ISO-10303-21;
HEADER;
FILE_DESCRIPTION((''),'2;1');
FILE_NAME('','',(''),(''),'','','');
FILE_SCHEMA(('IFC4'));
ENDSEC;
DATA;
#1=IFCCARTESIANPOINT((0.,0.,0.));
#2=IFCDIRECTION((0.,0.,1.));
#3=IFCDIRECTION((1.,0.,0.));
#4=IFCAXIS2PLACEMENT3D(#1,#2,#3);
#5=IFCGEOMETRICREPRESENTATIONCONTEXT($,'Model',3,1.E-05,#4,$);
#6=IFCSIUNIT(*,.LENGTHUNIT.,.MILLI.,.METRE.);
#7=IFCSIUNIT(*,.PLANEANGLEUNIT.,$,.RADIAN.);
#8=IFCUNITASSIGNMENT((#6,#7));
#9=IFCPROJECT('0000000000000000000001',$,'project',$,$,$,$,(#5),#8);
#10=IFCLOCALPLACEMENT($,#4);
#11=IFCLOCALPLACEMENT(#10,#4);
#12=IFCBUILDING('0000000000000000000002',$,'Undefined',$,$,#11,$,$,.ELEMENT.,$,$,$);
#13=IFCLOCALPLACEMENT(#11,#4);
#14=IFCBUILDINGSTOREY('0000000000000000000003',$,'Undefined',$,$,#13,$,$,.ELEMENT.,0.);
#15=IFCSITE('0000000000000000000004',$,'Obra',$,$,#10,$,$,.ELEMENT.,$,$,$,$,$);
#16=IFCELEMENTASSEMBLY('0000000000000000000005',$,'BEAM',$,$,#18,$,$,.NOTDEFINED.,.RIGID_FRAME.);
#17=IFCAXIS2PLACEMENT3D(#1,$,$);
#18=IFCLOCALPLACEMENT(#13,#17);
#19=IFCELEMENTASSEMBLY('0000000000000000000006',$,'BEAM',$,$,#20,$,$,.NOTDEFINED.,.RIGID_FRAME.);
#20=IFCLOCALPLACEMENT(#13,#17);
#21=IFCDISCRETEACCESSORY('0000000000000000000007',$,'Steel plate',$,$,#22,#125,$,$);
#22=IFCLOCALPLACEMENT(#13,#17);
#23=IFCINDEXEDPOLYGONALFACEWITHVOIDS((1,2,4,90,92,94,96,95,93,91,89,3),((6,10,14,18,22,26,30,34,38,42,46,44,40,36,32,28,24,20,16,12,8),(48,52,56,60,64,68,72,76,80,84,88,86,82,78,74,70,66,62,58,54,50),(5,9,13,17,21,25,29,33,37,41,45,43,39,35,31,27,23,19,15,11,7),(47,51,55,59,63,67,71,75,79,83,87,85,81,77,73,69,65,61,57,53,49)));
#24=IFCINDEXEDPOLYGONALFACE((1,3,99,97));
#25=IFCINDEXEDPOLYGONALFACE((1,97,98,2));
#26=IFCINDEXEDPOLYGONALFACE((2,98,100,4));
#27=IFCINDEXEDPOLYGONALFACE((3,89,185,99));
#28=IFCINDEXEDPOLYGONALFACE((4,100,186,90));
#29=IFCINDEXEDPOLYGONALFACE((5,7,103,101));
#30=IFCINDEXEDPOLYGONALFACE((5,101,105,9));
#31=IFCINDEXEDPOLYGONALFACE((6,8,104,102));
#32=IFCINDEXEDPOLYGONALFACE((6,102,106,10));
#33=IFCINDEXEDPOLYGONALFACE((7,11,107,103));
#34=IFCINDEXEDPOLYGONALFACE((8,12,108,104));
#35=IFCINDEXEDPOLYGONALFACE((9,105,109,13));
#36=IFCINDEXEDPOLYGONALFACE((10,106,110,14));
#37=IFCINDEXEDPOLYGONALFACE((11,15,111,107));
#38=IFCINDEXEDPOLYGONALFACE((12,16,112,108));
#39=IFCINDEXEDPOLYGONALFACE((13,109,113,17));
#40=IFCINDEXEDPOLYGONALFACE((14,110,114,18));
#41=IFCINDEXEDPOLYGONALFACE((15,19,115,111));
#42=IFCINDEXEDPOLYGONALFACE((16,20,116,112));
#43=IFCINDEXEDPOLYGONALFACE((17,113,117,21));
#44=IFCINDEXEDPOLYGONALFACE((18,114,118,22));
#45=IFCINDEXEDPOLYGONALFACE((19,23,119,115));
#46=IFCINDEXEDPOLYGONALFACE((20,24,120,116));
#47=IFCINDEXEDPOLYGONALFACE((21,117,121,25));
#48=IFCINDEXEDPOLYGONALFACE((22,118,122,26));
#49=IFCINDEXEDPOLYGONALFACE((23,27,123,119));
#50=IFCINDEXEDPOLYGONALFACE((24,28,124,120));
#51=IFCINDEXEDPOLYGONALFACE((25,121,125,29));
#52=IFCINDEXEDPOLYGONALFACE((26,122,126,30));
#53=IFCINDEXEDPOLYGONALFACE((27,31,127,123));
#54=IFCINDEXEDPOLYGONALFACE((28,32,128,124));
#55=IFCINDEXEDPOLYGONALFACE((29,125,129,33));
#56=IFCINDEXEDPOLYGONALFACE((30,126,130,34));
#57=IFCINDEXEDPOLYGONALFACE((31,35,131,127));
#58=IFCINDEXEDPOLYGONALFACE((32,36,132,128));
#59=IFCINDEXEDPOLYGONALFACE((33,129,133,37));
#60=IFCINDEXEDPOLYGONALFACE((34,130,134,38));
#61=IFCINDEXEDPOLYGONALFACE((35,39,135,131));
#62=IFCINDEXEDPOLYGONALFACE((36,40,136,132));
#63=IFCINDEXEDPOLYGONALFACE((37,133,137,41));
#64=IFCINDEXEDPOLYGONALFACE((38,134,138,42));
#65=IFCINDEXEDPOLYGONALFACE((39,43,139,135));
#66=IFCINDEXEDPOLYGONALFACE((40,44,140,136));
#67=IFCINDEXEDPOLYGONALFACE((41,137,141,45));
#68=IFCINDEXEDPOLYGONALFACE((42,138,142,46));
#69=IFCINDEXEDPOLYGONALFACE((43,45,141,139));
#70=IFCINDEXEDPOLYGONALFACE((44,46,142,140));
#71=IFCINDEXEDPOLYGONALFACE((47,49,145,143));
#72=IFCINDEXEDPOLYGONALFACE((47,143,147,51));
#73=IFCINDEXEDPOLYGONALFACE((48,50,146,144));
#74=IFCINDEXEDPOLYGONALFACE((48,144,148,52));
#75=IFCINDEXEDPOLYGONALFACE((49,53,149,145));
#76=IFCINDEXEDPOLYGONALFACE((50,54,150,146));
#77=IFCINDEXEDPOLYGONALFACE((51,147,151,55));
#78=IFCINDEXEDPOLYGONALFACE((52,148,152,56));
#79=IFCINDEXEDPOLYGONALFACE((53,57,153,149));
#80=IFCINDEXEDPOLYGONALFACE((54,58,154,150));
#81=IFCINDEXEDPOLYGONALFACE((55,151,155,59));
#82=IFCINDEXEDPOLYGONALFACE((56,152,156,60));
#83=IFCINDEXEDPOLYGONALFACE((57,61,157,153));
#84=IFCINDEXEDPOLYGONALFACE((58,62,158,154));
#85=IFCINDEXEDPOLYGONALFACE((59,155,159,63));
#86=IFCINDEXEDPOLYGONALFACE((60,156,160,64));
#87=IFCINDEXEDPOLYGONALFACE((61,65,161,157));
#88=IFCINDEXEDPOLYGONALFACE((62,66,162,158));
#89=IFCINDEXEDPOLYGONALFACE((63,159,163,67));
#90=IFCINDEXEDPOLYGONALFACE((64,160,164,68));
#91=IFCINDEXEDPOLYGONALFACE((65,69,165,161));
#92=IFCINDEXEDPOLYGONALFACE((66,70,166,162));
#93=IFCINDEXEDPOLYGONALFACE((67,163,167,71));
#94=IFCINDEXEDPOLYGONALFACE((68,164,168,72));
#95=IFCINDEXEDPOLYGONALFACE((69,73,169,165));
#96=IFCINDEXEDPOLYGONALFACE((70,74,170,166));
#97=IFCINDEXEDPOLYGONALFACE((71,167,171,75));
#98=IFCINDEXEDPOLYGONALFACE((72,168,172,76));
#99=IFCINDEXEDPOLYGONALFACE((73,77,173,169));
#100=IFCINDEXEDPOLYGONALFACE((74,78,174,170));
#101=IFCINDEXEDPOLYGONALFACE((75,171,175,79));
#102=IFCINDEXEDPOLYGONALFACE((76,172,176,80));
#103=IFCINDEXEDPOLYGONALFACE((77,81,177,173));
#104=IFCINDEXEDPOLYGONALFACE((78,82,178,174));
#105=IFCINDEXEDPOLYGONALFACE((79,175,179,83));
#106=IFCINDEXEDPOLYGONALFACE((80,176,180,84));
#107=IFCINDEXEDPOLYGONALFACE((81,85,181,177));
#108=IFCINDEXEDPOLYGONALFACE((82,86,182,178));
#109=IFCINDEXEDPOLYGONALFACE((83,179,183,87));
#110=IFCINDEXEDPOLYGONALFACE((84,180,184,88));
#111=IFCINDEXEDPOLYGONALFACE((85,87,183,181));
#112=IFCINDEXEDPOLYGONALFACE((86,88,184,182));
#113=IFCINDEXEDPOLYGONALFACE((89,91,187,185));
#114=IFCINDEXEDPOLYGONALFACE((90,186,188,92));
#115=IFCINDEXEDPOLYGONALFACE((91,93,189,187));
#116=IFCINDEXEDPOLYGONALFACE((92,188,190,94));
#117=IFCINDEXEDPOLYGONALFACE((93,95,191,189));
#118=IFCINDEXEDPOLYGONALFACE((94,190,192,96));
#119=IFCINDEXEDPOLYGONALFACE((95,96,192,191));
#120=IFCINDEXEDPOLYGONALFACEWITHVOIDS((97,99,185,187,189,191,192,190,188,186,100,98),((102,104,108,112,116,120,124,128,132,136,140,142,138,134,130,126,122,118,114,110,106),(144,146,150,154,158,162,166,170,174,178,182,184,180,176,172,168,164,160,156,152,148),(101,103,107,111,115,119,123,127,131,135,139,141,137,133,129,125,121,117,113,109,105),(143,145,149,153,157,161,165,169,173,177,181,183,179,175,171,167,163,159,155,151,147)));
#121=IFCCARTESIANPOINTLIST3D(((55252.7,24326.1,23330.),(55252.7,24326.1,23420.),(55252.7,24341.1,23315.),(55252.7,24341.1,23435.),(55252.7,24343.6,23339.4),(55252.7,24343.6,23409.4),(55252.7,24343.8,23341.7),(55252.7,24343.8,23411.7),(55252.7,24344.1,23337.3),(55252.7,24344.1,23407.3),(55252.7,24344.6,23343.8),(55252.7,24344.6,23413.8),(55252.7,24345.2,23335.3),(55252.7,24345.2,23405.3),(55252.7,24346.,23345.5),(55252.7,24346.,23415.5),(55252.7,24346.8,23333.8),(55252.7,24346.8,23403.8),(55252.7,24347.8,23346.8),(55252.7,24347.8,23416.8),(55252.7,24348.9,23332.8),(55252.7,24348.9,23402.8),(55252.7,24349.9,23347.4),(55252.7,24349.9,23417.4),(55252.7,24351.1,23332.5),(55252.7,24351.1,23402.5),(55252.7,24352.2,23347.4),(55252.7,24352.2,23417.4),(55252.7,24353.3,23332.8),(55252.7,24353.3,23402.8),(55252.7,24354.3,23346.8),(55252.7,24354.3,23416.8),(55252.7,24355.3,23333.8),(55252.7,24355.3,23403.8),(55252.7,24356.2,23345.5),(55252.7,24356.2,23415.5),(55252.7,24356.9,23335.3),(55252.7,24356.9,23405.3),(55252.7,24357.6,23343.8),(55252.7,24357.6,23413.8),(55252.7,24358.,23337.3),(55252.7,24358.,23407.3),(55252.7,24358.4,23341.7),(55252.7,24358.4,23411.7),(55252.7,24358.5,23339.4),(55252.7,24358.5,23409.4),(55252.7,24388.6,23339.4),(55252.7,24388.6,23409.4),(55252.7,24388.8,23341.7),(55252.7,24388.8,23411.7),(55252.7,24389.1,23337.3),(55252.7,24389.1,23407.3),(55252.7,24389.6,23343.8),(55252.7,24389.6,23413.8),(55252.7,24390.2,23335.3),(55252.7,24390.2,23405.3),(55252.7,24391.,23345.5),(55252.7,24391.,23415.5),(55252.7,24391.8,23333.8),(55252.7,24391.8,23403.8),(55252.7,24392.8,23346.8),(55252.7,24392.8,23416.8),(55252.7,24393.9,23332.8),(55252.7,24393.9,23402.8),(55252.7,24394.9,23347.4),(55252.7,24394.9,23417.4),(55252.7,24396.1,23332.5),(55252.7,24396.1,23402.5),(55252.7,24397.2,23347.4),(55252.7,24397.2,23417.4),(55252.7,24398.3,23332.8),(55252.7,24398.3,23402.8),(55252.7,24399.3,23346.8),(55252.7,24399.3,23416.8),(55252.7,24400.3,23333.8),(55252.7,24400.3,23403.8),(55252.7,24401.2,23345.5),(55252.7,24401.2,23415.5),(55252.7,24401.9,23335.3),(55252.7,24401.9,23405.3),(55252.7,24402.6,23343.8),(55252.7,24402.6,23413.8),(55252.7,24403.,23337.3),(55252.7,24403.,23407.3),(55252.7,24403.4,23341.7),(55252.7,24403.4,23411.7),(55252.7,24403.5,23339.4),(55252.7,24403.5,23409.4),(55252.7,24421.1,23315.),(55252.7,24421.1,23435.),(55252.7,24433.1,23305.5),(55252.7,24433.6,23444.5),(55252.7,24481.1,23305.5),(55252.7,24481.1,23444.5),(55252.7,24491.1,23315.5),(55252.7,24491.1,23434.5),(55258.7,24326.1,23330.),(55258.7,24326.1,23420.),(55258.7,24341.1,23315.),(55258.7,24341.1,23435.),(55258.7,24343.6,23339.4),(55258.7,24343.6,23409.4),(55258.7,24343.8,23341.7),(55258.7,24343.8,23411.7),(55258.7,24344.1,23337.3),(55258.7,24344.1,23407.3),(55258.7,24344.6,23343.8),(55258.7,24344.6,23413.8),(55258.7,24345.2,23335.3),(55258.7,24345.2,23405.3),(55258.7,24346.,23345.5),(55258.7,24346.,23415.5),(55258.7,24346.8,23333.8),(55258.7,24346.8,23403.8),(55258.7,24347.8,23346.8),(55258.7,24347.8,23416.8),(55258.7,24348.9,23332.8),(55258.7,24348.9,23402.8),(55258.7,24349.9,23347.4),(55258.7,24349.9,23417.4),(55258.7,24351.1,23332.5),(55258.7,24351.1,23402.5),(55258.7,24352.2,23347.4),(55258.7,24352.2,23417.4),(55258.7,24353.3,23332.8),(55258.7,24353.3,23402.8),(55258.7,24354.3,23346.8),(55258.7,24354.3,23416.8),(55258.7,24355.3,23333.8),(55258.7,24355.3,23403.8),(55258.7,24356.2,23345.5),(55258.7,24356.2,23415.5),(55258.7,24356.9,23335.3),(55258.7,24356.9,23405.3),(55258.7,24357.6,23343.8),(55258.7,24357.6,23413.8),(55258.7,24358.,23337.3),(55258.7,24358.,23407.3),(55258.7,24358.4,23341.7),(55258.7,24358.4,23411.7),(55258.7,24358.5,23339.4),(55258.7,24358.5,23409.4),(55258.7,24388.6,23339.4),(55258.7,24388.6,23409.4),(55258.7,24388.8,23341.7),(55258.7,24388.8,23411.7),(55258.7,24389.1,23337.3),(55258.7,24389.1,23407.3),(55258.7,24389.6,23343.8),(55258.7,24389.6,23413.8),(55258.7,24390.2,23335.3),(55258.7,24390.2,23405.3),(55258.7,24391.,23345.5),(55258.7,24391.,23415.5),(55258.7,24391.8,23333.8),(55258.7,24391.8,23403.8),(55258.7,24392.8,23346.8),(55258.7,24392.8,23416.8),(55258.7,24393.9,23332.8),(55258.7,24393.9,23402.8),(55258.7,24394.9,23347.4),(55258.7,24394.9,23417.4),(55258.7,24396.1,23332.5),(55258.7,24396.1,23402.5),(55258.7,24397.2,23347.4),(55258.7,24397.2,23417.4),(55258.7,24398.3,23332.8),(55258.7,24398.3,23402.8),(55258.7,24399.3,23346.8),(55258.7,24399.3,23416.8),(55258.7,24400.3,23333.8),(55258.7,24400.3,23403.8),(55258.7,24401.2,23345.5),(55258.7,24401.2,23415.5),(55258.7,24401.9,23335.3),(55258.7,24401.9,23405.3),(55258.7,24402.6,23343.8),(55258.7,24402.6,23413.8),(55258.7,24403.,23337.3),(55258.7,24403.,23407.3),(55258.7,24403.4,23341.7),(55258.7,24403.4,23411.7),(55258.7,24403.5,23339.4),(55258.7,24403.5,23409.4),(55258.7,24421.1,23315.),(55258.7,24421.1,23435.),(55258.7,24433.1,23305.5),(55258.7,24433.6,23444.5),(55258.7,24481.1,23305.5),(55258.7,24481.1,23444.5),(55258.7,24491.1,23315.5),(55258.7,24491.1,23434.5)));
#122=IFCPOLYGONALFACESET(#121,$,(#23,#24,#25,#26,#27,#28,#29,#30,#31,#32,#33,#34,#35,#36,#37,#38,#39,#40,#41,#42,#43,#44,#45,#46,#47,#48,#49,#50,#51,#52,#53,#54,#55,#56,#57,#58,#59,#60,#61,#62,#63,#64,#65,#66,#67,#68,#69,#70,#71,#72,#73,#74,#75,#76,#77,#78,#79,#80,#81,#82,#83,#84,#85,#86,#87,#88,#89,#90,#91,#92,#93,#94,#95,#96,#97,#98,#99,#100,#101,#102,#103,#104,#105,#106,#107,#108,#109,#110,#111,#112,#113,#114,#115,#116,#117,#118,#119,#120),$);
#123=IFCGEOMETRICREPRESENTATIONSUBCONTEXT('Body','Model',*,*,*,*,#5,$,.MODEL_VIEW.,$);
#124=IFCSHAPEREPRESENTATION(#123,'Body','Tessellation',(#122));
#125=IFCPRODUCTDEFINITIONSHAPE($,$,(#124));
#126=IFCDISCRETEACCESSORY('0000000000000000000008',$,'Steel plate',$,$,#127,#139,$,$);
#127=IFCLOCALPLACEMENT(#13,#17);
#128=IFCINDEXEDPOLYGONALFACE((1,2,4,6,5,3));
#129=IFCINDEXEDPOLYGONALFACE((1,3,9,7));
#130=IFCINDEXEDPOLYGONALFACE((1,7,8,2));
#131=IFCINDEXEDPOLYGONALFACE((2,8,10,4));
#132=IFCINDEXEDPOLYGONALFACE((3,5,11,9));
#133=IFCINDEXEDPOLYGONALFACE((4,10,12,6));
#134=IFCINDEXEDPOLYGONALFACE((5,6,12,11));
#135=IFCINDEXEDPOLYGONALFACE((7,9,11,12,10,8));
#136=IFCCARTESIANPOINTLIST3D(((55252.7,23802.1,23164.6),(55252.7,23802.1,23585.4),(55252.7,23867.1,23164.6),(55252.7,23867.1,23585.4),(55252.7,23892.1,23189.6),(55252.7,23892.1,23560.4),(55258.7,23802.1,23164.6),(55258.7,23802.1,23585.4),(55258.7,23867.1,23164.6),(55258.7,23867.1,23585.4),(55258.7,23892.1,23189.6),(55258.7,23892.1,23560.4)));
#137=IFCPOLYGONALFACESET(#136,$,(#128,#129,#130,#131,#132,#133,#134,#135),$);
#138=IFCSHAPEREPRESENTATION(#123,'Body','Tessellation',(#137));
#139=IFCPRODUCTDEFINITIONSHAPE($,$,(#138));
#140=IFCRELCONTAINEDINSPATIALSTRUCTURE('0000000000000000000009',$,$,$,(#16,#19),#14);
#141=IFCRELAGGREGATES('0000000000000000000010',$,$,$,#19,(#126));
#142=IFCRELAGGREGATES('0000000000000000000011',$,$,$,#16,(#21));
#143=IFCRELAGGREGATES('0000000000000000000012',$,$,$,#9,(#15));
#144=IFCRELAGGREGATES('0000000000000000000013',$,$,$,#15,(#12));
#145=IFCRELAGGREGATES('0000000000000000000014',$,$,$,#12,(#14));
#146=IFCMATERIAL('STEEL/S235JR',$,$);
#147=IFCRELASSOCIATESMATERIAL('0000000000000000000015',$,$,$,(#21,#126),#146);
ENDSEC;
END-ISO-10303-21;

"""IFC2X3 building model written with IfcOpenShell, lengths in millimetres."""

from ifc_helpers import new_model, si_unit, frame, origin_with_axes, origin_2d_with_axis, place, context, subcontext, project, spatial, polyline, circle, outline, extrude, source, transform, mapped, material, element, aggregate, save


model = new_model("IFC2X3")

# Units and contexts
model_context = context("Model", 3, precision=1e-05, world=origin_with_axes())
body_context = subcontext(model_context, "Body", "Model", "MODEL_VIEW")
ifc_project = project(units=[si_unit("LENGTHUNIT", "METRE", prefix="MILLI"), si_unit("PLANEANGLEUNIT", "RADIAN")], contexts=[model_context])

# Site, building, storey
site_placement = place(None, origin_with_axes())
site = spatial("IfcSite", under=ifc_project, at=site_placement, Name="Obra", CompositionType="ELEMENT")
building_placement = place(site_placement, origin_with_axes())
building = spatial("IfcBuilding", under=site, at=building_placement, Name="Undefined", CompositionType="ELEMENT")
storey_placement = place(building_placement, origin_with_axes())
storey = spatial("IfcBuildingStorey", under=building, at=storey_placement, Name="Undefined", CompositionType="ELEMENT", Elevation=0.0)

# Shared definitions
ifc_material_1 = material(Name="STEEL/S235JR")

# Element assembly
assembly_1_placement = place(storey_placement, origin_with_axes())
assembly_1 = element("IfcElementAssembly", 1, at=assembly_1_placement, inside=storey, Name="BEAM", AssemblyPlace="NOTDEFINED", PredefinedType="RIGID_FRAME")
shared_shape_1 = source(origin_with_axes(), body_context, "Body", "SweptSolid", [
    extrude(circle(Radius=7.5, at=origin_2d_with_axis()), frame((0.0, 2.4, 0.0), z_axis=(0.0, 1.0, 0.0), x_axis=(1.0, 0.0, 0.0)), (0.0, 0.0, 1.0), 6.2),
])

# Element assembly
assembly_2_placement = place(storey_placement, origin_with_axes())
assembly_2 = element("IfcElementAssembly", 2, at=assembly_2_placement, inside=storey, Name="BEAM", AssemblyPlace="NOTDEFINED", PredefinedType="RIGID_FRAME")

# Discrete accessory, opening
discrete_accessory_1_placement = place(assembly_1_placement, frame((55255.7, 24491.1, 23315.5), z_axis=(-1.0, 0.0, 0.0), x_axis=(0.0, -0.707107, -0.707107)))
discrete_accessory_1 = element("IfcDiscreteAccessory", 3, at=discrete_accessory_1_placement, material=ifc_material_1, Name="Steel plate", context=body_context, shape_type="SweptSolid", body=[
    extrude(outline(polyline([(0.0, 0.0), (14.1, 0.0), (48.1, 33.9), (49.9, 49.1), (106.4, 105.7), (106.4, 126.9), (42.8, 190.6), (21.6, 190.6), (-35.0, 134.0), (-50.6, 131.9), (-84.1, 98.3), (-84.1, 84.1), (0.0, 0.0)])), frame((0.0, 0.0, -3.0), z_axis=(0.0, 0.0, 1.0), x_axis=(1.0, 0.0, 0.0)), (0.0, 0.0, 1.0), 6.0),
])
opening_1_placement = place(assembly_1_placement, frame((55250.2, 24373.6, 23410.0), z_axis=(0.0, -1.0, 0.0), x_axis=(0.0, 0.0, -1.0)))
element("IfcOpeningElement", 4, at=opening_1_placement, cuts=discrete_accessory_1, ObjectType="Opening", context=body_context, shape_type="MappedRepresentation", body=[
    mapped(shared_shape_1, transform((0.0, 0.0, -22.5))),
    mapped(shared_shape_1, transform((70.0, 0.0, -22.5))),
    mapped(shared_shape_1, transform((0.0, 0.0, 22.5))),
    mapped(shared_shape_1, transform((70.0, 0.0, 22.5))),
])

# Discrete accessory
discrete_accessory_2_placement = place(assembly_2_placement, frame((55255.7, 23892.1, 23164.6), z_axis=(-1.0, 0.0, 0.0), x_axis=(0.0, -1.0, 0.0)))
discrete_accessory_2 = element("IfcDiscreteAccessory", 5, at=discrete_accessory_2_placement, material=ifc_material_1, Name="Steel plate", context=body_context, shape_type="SweptSolid", body=[
    extrude(outline(polyline([(0.0, 25.0), (25.0, 0.0), (90.0, 0.0), (90.0, 420.8), (25.0, 420.8), (0.0, 395.8), (0.0, 25.0)])), frame((0.0, 0.0, -3.0), z_axis=(0.0, 0.0, 1.0), x_axis=(1.0, 0.0, 0.0)), (0.0, 0.0, 1.0), 6.0),
])

aggregate(assembly_2, [discrete_accessory_2])
aggregate(assembly_1, [discrete_accessory_1])

save(model, "model.ifc")
